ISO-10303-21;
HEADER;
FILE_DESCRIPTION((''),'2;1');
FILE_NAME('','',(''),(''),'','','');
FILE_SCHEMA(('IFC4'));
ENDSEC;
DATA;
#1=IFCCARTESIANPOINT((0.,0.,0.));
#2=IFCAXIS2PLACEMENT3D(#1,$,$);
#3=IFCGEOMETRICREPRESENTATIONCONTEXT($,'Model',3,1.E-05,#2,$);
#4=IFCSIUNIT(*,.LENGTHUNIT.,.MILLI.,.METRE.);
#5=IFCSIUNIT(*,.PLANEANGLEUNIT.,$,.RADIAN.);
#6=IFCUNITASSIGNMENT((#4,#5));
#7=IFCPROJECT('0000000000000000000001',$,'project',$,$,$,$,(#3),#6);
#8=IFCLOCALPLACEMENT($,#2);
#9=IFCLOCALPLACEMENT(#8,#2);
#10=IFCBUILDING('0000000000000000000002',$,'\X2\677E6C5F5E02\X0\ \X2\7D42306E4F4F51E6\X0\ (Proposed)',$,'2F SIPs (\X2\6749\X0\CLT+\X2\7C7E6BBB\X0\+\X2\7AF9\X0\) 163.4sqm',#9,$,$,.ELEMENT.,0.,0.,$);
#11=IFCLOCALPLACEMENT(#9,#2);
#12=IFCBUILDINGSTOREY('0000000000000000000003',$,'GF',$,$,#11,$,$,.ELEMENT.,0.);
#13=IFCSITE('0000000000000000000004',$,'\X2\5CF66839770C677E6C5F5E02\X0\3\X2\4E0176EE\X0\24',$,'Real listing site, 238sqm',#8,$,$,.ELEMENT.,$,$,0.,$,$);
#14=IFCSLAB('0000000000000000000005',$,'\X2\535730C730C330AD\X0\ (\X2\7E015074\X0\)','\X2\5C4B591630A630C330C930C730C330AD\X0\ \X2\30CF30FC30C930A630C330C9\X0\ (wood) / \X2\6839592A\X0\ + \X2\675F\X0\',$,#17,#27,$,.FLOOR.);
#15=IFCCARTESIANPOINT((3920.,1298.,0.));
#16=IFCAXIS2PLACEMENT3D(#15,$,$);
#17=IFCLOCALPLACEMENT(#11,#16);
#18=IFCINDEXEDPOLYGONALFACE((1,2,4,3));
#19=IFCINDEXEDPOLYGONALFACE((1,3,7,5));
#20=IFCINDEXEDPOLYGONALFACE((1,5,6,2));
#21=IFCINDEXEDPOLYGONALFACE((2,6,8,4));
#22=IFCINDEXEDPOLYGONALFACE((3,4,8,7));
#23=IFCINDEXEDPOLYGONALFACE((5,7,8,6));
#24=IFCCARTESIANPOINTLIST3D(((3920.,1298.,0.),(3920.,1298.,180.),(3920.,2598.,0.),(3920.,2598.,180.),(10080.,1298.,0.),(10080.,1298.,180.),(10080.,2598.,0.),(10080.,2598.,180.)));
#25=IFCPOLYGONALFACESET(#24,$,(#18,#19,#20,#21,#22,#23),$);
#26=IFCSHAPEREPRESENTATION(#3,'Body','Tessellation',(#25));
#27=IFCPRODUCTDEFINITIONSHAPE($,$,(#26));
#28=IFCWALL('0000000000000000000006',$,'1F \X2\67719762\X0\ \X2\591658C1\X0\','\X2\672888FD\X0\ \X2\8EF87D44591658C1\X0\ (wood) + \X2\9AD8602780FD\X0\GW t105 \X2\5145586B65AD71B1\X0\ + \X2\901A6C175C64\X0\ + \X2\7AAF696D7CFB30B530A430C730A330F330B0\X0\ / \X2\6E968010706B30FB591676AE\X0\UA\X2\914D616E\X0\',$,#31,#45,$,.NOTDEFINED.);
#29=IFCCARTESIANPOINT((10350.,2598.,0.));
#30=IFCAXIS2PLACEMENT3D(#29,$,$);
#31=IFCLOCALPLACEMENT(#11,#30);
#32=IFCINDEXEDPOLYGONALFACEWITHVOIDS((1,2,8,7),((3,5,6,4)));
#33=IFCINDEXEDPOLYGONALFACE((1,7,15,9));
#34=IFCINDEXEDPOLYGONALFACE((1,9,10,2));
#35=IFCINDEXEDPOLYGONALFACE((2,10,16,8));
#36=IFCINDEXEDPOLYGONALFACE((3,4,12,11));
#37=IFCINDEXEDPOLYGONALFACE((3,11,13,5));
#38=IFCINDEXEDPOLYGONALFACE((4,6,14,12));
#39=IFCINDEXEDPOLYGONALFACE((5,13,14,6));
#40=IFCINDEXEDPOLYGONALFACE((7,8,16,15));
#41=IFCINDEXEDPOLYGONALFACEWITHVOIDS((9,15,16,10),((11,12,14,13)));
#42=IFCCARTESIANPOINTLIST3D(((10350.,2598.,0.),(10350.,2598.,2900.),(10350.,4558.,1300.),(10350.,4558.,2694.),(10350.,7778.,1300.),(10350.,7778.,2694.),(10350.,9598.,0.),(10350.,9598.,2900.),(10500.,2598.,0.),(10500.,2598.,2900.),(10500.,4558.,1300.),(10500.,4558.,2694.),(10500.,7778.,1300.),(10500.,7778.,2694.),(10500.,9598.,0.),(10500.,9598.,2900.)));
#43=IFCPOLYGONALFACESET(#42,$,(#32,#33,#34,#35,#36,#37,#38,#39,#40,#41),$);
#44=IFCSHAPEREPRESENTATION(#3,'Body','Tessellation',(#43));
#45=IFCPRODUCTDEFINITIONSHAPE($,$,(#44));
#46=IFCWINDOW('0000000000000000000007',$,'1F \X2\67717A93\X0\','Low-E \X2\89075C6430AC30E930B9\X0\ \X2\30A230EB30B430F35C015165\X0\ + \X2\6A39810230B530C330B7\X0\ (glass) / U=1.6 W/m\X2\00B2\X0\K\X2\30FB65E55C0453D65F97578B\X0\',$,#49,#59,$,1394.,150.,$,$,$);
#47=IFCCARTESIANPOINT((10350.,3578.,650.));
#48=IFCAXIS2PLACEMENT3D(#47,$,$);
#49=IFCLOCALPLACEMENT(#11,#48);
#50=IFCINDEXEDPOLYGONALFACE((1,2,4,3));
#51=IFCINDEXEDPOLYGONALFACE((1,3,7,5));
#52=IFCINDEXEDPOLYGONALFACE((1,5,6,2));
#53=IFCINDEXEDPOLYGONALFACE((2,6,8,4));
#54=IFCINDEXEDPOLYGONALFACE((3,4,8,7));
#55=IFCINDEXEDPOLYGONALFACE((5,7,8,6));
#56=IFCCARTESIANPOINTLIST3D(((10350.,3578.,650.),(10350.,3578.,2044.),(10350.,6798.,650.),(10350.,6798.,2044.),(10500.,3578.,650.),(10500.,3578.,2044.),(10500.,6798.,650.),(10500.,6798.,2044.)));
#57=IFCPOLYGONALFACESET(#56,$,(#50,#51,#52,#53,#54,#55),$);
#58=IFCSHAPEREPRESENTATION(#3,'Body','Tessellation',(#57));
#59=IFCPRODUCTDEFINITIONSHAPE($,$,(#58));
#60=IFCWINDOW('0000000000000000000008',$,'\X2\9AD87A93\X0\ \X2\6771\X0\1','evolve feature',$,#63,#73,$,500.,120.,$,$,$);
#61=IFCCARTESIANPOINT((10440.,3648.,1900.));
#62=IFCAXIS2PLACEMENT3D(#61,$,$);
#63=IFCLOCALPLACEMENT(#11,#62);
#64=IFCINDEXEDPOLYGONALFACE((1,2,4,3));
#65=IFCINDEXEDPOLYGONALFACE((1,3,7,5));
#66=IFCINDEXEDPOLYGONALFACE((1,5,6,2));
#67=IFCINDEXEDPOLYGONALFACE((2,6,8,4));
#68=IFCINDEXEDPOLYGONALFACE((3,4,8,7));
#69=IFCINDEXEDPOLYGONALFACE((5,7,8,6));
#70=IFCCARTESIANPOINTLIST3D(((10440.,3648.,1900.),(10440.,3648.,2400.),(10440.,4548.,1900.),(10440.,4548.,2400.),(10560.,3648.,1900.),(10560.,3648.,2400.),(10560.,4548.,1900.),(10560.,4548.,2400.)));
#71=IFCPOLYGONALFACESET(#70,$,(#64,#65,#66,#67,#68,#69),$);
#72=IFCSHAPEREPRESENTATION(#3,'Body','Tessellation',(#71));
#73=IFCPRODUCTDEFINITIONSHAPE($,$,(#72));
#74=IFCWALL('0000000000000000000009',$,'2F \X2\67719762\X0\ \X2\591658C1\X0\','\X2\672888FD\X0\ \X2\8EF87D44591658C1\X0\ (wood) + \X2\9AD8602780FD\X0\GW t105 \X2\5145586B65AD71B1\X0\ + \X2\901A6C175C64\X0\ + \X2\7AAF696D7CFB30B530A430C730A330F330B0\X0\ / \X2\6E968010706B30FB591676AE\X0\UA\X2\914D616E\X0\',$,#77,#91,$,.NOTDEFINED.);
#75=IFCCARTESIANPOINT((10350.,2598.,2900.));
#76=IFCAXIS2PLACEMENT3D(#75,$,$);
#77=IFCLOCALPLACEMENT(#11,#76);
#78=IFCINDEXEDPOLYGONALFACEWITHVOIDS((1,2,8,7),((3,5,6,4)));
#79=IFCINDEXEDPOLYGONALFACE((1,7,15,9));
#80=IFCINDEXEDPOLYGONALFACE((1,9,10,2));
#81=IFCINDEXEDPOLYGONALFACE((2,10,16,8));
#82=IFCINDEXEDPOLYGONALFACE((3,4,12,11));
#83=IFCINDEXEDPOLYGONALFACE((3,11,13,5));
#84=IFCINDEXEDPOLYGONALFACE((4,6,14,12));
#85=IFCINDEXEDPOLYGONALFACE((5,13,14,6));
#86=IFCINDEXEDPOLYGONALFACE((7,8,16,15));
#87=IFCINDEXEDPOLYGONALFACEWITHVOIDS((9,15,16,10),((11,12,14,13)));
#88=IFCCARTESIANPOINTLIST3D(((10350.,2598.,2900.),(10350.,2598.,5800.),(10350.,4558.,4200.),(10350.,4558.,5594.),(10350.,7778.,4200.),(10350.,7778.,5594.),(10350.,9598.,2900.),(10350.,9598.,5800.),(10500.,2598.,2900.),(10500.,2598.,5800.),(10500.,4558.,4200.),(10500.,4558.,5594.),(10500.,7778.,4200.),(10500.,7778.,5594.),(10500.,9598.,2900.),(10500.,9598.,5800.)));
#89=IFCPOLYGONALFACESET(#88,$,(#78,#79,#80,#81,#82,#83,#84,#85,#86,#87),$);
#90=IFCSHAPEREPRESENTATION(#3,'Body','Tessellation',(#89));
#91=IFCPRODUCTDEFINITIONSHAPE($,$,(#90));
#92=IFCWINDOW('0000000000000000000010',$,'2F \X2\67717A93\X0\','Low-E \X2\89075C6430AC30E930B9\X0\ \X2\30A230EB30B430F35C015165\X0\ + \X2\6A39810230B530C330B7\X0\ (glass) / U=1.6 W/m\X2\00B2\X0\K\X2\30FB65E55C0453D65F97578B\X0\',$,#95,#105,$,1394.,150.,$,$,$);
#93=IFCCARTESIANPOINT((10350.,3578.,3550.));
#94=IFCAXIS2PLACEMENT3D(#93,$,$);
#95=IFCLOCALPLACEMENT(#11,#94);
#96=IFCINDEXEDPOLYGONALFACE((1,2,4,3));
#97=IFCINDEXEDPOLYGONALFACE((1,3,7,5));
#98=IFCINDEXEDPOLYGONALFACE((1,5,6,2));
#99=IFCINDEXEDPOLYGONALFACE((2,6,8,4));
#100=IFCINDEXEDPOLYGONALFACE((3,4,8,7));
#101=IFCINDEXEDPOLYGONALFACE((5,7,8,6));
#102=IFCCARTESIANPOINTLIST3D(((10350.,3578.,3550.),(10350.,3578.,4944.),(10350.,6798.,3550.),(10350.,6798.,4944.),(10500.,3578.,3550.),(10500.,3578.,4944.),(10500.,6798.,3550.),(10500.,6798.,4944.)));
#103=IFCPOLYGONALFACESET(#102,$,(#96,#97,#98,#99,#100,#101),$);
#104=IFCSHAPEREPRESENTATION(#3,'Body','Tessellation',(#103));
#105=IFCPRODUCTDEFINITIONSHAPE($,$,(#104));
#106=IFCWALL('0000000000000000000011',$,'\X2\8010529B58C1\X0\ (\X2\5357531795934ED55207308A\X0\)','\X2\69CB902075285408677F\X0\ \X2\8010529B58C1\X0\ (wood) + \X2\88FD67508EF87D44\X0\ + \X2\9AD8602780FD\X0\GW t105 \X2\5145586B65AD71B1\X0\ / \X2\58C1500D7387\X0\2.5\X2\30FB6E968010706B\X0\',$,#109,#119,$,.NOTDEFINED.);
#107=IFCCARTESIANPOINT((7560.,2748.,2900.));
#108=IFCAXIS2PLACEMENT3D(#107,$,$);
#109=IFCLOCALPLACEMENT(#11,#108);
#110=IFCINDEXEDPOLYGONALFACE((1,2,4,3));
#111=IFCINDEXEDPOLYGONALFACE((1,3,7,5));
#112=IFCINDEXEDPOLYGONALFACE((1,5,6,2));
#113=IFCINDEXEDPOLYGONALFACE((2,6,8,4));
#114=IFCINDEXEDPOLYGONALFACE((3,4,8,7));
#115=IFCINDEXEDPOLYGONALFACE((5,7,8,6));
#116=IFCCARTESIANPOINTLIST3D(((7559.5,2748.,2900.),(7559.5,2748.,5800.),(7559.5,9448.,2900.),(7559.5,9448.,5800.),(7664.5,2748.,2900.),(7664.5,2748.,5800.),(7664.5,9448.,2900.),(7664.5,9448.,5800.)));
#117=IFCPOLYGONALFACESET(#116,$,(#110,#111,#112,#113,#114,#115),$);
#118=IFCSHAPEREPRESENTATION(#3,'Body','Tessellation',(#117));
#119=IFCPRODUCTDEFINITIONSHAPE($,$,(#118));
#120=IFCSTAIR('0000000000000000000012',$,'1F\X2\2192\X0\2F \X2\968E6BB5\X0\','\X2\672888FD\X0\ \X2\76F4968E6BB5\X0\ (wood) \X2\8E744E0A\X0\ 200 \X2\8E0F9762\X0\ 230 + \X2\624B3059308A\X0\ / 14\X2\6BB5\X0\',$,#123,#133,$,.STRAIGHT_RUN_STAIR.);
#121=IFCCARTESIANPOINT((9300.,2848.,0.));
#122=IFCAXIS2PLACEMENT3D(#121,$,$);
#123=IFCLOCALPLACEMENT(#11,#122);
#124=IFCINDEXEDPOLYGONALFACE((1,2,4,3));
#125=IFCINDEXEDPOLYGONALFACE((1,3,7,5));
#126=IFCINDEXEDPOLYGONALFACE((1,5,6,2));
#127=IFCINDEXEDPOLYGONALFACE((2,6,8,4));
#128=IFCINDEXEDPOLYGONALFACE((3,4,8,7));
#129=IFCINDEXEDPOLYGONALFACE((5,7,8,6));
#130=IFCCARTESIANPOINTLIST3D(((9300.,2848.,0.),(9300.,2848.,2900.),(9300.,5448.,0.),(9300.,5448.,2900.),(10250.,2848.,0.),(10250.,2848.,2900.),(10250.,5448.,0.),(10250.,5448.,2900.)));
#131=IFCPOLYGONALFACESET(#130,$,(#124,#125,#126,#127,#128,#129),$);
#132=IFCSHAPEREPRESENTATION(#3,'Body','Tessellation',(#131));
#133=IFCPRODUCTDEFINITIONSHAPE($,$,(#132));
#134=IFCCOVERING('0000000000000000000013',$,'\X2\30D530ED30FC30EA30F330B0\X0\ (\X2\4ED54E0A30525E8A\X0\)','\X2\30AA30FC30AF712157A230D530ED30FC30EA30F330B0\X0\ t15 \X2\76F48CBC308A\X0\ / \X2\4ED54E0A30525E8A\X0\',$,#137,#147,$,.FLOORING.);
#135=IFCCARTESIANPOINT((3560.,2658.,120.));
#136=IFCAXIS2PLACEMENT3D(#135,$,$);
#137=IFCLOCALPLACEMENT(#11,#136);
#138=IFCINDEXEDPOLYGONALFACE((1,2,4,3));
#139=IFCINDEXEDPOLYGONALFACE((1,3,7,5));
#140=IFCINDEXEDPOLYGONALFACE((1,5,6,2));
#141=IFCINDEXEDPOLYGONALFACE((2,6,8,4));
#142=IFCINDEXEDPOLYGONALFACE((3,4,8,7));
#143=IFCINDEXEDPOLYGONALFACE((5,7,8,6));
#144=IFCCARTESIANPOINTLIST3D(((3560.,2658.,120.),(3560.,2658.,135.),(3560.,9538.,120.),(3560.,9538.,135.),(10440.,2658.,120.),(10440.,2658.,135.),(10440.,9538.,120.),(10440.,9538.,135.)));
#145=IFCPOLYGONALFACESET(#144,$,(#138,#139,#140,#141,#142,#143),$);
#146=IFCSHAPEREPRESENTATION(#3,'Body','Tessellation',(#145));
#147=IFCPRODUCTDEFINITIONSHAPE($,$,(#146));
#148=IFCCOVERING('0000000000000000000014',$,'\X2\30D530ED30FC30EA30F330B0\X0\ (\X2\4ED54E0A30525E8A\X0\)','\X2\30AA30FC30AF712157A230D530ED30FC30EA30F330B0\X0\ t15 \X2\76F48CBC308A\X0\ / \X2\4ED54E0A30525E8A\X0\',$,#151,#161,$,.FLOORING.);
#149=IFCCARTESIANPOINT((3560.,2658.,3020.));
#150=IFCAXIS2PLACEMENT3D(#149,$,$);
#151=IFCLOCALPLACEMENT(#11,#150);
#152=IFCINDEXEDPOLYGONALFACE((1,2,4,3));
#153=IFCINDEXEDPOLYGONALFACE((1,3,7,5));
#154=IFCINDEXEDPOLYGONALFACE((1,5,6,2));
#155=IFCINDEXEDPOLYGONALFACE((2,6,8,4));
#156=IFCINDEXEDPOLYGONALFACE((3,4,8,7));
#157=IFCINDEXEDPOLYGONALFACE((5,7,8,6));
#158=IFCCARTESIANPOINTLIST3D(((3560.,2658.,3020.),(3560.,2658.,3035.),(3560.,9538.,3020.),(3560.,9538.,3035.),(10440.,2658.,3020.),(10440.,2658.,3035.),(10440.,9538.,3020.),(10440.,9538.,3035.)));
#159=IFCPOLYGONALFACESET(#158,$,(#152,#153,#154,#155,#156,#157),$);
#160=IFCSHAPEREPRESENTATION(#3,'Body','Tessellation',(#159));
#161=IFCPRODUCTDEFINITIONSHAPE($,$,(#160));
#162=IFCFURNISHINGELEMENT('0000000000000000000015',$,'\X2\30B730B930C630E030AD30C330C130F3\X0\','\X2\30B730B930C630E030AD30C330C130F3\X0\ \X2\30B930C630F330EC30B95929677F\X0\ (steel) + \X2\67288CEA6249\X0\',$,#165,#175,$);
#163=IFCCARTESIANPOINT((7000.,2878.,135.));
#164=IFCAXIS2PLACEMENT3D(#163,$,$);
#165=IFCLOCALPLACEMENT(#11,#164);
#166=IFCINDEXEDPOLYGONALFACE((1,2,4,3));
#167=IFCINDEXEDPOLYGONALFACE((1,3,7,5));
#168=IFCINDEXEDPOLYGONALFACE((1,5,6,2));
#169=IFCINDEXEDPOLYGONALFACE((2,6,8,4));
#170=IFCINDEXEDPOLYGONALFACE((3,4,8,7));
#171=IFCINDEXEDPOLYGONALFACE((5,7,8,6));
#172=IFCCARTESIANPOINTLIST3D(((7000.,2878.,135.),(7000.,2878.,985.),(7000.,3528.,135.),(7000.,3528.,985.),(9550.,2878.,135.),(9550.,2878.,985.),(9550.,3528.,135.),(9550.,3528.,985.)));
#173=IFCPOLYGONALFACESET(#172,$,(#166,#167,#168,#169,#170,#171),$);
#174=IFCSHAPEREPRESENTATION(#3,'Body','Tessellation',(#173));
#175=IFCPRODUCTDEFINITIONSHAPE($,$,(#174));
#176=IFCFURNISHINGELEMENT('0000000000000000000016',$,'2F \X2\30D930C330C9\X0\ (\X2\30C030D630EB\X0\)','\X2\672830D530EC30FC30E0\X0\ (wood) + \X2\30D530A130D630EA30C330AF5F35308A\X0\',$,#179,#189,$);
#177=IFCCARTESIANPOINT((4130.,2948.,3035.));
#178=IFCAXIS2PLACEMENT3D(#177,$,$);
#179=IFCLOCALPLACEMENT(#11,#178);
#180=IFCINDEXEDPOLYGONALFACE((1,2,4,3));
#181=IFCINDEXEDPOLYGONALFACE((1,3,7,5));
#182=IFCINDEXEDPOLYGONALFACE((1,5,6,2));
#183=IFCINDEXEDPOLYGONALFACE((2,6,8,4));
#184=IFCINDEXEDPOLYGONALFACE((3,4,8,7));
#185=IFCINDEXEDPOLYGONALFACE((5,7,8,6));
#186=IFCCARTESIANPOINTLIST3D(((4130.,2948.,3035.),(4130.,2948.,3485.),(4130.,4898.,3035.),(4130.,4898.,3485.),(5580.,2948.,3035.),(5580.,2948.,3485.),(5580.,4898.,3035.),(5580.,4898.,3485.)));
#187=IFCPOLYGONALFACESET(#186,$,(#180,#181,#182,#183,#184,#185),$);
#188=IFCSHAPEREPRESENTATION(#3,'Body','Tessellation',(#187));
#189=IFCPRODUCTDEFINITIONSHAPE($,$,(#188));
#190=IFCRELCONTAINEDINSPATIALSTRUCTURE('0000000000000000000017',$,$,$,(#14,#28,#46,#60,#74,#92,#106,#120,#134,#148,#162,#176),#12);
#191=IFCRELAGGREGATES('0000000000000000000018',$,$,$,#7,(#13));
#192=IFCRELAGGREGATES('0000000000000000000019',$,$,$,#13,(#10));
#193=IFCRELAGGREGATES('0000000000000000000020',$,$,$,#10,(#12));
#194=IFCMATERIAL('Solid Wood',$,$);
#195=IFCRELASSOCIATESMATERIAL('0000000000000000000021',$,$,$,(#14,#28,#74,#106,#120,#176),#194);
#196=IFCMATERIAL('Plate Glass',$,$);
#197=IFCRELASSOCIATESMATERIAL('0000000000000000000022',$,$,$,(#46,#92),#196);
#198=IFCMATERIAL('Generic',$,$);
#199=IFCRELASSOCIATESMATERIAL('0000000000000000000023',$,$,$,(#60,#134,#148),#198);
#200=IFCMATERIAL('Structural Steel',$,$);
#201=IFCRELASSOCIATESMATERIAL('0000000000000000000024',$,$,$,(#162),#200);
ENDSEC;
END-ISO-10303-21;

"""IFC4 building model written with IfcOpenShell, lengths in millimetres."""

from ifc_helpers import new_model, si_unit, frame, frame_2d, origin, place, context, project, spatial, rectangle, extrude, material, element, fill, save


model = new_model("IFC4")

# Units and contexts
model_context = context("Model", 3, precision=1e-05, world=origin())
ifc_project = project(units=[si_unit("LENGTHUNIT", "METRE", prefix="MILLI"), si_unit("PLANEANGLEUNIT", "RADIAN")], contexts=[model_context])

# Site, building, storey
site_placement = place(None, origin())
site = spatial("IfcSite", under=ifc_project, at=site_placement, Name="島根県松江市3丁目24", ObjectType="Real listing site, 238sqm", CompositionType="ELEMENT", RefElevation=0.0)
building_placement = place(site_placement, origin())
building = spatial("IfcBuilding", under=site, at=building_placement, Name="松江市 終の住処 (Proposed)", ObjectType="2F SIPs (杉CLT+籾殻+竹) 163.4sqm", CompositionType="ELEMENT", ElevationOfRefHeight=0.0, ElevationOfTerrain=0.0)
storey_placement = place(building_placement, origin())
storey = spatial("IfcBuildingStorey", under=building, at=storey_placement, Name="GF", CompositionType="ELEMENT", Elevation=0.0)

# Slab
ifc_material_1 = material(Name="Solid Wood")
slab_placement = place(storey_placement, frame((3920.0, 1298.0, 0.0)))
element("IfcSlab", 1, at=slab_placement, inside=storey, material=ifc_material_1, Name="南デッキ (縁側)", Description="屋外ウッドデッキ ハードウッド (wood) / 根太 + 束", PredefinedType="FLOOR", context=model_context, shape_type="SweptSolid", body=[
    extrude(rectangle(XDim=6160.0, YDim=1300.0, at=frame_2d((3080.0, 650.0))), frame((3920.0, 1298.0, 0.0)), (0.0, 0.0, 1.0), 180.0),
])

# Wall, openings, windows
wall_1_placement = place(storey_placement, frame((10350.0, 2598.0, 0.0)))
wall_1 = element("IfcWall", 2, at=wall_1_placement, inside=storey, material=ifc_material_1, Name="1F 東面 外壁", Description="木製 軸組外壁 (wood) + 高性能GW t105 充填断熱 + 通気層 + 窯業系サイディング / 準耐火・外皮UA配慮", PredefinedType="NOTDEFINED", context=model_context, shape_type="SweptSolid", body=[
    extrude(rectangle(XDim=150.0, YDim=7000.0, at=frame_2d((75.0, 3500.0))), frame((10350.0, 2598.0, 0.0)), (0.0, 0.0, 1.0), 2900.0),
])
opening_1_placement = place(storey_placement, frame((10350.0, 3578.0, 650.0)))
opening_1 = element("IfcOpeningElement", 3, at=opening_1_placement, cuts=wall_1, PredefinedType="NOTDEFINED", context=model_context, shape_type="SweptSolid", body=[
    extrude(rectangle(XDim=150.0, YDim=3220.0, at=frame_2d((75.0, 1610.0))), frame((10350.0, 3578.0, 650.0)), (0.0, 0.0, 1.0), 1394.0),
])
opening_2_placement = place(storey_placement, frame((10440.0, 3648.0, 1900.0)))
opening_2 = element("IfcOpeningElement", 4, at=opening_2_placement, cuts=wall_1, PredefinedType="NOTDEFINED", context=model_context, shape_type="SweptSolid", body=[
    extrude(rectangle(XDim=120.0, YDim=900.0, at=frame_2d((60.0, 450.0))), frame((10440.0, 3648.0, 1900.0)), (0.0, 0.0, 1.0), 500.0),
])
ifc_material_2 = material(Name="Plate Glass")
window_1_placement = place(storey_placement, frame((10350.0, 3578.0, 650.0)))
window_1 = element("IfcWindow", 5, at=window_1_placement, inside=storey, material=ifc_material_2, Name="1F 東窓", Description="Low-E 複層ガラス アルゴン封入 + 樹脂サッシ (glass) / U=1.6 W/m²K・日射取得型", OverallHeight=1394.0, OverallWidth=150.0, context=model_context, shape_type="SweptSolid", body=[
    extrude(rectangle(XDim=150.0, YDim=3220.0, at=frame_2d((75.0, 1610.0))), frame((10350.0, 3578.0, 650.0)), (0.0, 0.0, 1.0), 1394.0),
])
fill(opening_1, window_1)
ifc_material_3 = material(Name="Generic")
window_2_placement = place(storey_placement, frame((10440.0, 3648.0, 1900.0)))
window_2 = element("IfcWindow", 6, at=window_2_placement, inside=storey, material=ifc_material_3, Name="高窓 東1", Description="evolve feature", OverallHeight=500.0, OverallWidth=120.0, context=model_context, shape_type="SweptSolid", body=[
    extrude(rectangle(XDim=120.0, YDim=900.0, at=frame_2d((60.0, 450.0))), frame((10440.0, 3648.0, 1900.0)), (0.0, 0.0, 1.0), 500.0),
])
fill(opening_2, window_2)

# Wall, opening, window
wall_2_placement = place(storey_placement, frame((10350.0, 2598.0, 2900.0)))
wall_2 = element("IfcWall", 7, at=wall_2_placement, inside=storey, material=ifc_material_1, Name="2F 東面 外壁", Description="木製 軸組外壁 (wood) + 高性能GW t105 充填断熱 + 通気層 + 窯業系サイディング / 準耐火・外皮UA配慮", PredefinedType="NOTDEFINED", context=model_context, shape_type="SweptSolid", body=[
    extrude(rectangle(XDim=150.0, YDim=7000.0, at=frame_2d((75.0, 3500.0))), frame((10350.0, 2598.0, 2900.0)), (0.0, 0.0, 1.0), 2900.0),
])
opening_3_placement = place(storey_placement, frame((10350.0, 3578.0, 3550.0)))
opening_3 = element("IfcOpeningElement", 8, at=opening_3_placement, cuts=wall_2, PredefinedType="NOTDEFINED", context=model_context, shape_type="SweptSolid", body=[
    extrude(rectangle(XDim=150.0, YDim=3220.0, at=frame_2d((75.0, 1610.0))), frame((10350.0, 3578.0, 3550.0)), (0.0, 0.0, 1.0), 1394.0),
])
window_3_placement = place(storey_placement, frame((10350.0, 3578.0, 3550.0)))
window_3 = element("IfcWindow", 9, at=window_3_placement, inside=storey, material=ifc_material_2, Name="2F 東窓", Description="Low-E 複層ガラス アルゴン封入 + 樹脂サッシ (glass) / U=1.6 W/m²K・日射取得型", OverallHeight=1394.0, OverallWidth=150.0, context=model_context, shape_type="SweptSolid", body=[
    extrude(rectangle(XDim=150.0, YDim=3220.0, at=frame_2d((75.0, 1610.0))), frame((10350.0, 3578.0, 3550.0)), (0.0, 0.0, 1.0), 1394.0),
])
fill(opening_3, window_3)

# Wall
wall_3_placement = place(storey_placement, frame((7560.0, 2748.0, 2900.0)))
element("IfcWall", 10, at=wall_3_placement, inside=storey, material=ifc_material_1, Name="耐力壁 (南北間仕切り)", Description="構造用合板 耐力壁 (wood) + 製材軸組 + 高性能GW t105 充填断熱 / 壁倍率2.5・準耐火", PredefinedType="NOTDEFINED", context=model_context, shape_type="SweptSolid", body=[
    extrude(rectangle(XDim=105.0, YDim=6700.0, at=frame_2d((52.0, 3350.0))), frame((7560.0, 2748.0, 2900.0)), (0.0, 0.0, 1.0), 2900.0),
])

# Stair
stair_placement = place(storey_placement, frame((9300.0, 2848.0, 0.0)))
element("IfcStair", 11, at=stair_placement, inside=storey, material=ifc_material_1, Name="1F→2F 階段", Description="木製 直階段 (wood) 蹴上 200 踏面 230 + 手すり / 14段", PredefinedType="STRAIGHT_RUN_STAIR", context=model_context, shape_type="SweptSolid", body=[
    extrude(rectangle(XDim=950.0, YDim=2600.0, at=frame_2d((475.0, 1300.0))), frame((9300.0, 2848.0, 0.0)), (0.0, 0.0, 1.0), 2900.0),
])

# Coverings
covering_1_placement = place(storey_placement, frame((3560.0, 2658.0, 120.0)))
element("IfcCovering", 12, at=covering_1_placement, inside=storey, material=ifc_material_3, Name="フローリング (仕上げ床)", Description="オーク無垢フローリング t15 直貼り / 仕上げ床", PredefinedType="FLOORING", context=model_context, shape_type="SweptSolid", body=[
    extrude(rectangle(XDim=6880.0, YDim=6880.0, at=frame_2d((3440.0, 3440.0))), frame((3560.0, 2658.0, 120.0)), (0.0, 0.0, 1.0), 15.0),
])
covering_2_placement = place(storey_placement, frame((3560.0, 2658.0, 3020.0)))
element("IfcCovering", 13, at=covering_2_placement, inside=storey, material=ifc_material_3, Name="フローリング (仕上げ床)", Description="オーク無垢フローリング t15 直貼り / 仕上げ床", PredefinedType="FLOORING", context=model_context, shape_type="SweptSolid", body=[
    extrude(rectangle(XDim=6880.0, YDim=6880.0, at=frame_2d((3440.0, 3440.0))), frame((3560.0, 2658.0, 3020.0)), (0.0, 0.0, 1.0), 15.0),
])

# Furnishing elements
ifc_material_4 = material(Name="Structural Steel")
furnishing_1_placement = place(storey_placement, frame((7000.0, 2878.0, 135.0)))
element("IfcFurnishingElement", 14, at=furnishing_1_placement, inside=storey, material=ifc_material_4, Name="システムキッチン", Description="システムキッチン ステンレス天板 (steel) + 木質扉", context=model_context, shape_type="SweptSolid", body=[
    extrude(rectangle(XDim=2550.0, YDim=650.0, at=frame_2d((1275.0, 325.0))), frame((7000.0, 2878.0, 135.0)), (0.0, 0.0, 1.0), 850.0),
])
furnishing_2_placement = place(storey_placement, frame((4130.0, 2948.0, 3035.0)))
element("IfcFurnishingElement", 15, at=furnishing_2_placement, inside=storey, material=ifc_material_1, Name="2F ベッド (ダブル)", Description="木フレーム (wood) + ファブリック張り", context=model_context, shape_type="SweptSolid", body=[
    extrude(rectangle(XDim=1450.0, YDim=1950.0, at=frame_2d((725.0, 975.0))), frame((4130.0, 2948.0, 3035.0)), (0.0, 0.0, 1.0), 450.0),
])

save(model, "model.ifc")
